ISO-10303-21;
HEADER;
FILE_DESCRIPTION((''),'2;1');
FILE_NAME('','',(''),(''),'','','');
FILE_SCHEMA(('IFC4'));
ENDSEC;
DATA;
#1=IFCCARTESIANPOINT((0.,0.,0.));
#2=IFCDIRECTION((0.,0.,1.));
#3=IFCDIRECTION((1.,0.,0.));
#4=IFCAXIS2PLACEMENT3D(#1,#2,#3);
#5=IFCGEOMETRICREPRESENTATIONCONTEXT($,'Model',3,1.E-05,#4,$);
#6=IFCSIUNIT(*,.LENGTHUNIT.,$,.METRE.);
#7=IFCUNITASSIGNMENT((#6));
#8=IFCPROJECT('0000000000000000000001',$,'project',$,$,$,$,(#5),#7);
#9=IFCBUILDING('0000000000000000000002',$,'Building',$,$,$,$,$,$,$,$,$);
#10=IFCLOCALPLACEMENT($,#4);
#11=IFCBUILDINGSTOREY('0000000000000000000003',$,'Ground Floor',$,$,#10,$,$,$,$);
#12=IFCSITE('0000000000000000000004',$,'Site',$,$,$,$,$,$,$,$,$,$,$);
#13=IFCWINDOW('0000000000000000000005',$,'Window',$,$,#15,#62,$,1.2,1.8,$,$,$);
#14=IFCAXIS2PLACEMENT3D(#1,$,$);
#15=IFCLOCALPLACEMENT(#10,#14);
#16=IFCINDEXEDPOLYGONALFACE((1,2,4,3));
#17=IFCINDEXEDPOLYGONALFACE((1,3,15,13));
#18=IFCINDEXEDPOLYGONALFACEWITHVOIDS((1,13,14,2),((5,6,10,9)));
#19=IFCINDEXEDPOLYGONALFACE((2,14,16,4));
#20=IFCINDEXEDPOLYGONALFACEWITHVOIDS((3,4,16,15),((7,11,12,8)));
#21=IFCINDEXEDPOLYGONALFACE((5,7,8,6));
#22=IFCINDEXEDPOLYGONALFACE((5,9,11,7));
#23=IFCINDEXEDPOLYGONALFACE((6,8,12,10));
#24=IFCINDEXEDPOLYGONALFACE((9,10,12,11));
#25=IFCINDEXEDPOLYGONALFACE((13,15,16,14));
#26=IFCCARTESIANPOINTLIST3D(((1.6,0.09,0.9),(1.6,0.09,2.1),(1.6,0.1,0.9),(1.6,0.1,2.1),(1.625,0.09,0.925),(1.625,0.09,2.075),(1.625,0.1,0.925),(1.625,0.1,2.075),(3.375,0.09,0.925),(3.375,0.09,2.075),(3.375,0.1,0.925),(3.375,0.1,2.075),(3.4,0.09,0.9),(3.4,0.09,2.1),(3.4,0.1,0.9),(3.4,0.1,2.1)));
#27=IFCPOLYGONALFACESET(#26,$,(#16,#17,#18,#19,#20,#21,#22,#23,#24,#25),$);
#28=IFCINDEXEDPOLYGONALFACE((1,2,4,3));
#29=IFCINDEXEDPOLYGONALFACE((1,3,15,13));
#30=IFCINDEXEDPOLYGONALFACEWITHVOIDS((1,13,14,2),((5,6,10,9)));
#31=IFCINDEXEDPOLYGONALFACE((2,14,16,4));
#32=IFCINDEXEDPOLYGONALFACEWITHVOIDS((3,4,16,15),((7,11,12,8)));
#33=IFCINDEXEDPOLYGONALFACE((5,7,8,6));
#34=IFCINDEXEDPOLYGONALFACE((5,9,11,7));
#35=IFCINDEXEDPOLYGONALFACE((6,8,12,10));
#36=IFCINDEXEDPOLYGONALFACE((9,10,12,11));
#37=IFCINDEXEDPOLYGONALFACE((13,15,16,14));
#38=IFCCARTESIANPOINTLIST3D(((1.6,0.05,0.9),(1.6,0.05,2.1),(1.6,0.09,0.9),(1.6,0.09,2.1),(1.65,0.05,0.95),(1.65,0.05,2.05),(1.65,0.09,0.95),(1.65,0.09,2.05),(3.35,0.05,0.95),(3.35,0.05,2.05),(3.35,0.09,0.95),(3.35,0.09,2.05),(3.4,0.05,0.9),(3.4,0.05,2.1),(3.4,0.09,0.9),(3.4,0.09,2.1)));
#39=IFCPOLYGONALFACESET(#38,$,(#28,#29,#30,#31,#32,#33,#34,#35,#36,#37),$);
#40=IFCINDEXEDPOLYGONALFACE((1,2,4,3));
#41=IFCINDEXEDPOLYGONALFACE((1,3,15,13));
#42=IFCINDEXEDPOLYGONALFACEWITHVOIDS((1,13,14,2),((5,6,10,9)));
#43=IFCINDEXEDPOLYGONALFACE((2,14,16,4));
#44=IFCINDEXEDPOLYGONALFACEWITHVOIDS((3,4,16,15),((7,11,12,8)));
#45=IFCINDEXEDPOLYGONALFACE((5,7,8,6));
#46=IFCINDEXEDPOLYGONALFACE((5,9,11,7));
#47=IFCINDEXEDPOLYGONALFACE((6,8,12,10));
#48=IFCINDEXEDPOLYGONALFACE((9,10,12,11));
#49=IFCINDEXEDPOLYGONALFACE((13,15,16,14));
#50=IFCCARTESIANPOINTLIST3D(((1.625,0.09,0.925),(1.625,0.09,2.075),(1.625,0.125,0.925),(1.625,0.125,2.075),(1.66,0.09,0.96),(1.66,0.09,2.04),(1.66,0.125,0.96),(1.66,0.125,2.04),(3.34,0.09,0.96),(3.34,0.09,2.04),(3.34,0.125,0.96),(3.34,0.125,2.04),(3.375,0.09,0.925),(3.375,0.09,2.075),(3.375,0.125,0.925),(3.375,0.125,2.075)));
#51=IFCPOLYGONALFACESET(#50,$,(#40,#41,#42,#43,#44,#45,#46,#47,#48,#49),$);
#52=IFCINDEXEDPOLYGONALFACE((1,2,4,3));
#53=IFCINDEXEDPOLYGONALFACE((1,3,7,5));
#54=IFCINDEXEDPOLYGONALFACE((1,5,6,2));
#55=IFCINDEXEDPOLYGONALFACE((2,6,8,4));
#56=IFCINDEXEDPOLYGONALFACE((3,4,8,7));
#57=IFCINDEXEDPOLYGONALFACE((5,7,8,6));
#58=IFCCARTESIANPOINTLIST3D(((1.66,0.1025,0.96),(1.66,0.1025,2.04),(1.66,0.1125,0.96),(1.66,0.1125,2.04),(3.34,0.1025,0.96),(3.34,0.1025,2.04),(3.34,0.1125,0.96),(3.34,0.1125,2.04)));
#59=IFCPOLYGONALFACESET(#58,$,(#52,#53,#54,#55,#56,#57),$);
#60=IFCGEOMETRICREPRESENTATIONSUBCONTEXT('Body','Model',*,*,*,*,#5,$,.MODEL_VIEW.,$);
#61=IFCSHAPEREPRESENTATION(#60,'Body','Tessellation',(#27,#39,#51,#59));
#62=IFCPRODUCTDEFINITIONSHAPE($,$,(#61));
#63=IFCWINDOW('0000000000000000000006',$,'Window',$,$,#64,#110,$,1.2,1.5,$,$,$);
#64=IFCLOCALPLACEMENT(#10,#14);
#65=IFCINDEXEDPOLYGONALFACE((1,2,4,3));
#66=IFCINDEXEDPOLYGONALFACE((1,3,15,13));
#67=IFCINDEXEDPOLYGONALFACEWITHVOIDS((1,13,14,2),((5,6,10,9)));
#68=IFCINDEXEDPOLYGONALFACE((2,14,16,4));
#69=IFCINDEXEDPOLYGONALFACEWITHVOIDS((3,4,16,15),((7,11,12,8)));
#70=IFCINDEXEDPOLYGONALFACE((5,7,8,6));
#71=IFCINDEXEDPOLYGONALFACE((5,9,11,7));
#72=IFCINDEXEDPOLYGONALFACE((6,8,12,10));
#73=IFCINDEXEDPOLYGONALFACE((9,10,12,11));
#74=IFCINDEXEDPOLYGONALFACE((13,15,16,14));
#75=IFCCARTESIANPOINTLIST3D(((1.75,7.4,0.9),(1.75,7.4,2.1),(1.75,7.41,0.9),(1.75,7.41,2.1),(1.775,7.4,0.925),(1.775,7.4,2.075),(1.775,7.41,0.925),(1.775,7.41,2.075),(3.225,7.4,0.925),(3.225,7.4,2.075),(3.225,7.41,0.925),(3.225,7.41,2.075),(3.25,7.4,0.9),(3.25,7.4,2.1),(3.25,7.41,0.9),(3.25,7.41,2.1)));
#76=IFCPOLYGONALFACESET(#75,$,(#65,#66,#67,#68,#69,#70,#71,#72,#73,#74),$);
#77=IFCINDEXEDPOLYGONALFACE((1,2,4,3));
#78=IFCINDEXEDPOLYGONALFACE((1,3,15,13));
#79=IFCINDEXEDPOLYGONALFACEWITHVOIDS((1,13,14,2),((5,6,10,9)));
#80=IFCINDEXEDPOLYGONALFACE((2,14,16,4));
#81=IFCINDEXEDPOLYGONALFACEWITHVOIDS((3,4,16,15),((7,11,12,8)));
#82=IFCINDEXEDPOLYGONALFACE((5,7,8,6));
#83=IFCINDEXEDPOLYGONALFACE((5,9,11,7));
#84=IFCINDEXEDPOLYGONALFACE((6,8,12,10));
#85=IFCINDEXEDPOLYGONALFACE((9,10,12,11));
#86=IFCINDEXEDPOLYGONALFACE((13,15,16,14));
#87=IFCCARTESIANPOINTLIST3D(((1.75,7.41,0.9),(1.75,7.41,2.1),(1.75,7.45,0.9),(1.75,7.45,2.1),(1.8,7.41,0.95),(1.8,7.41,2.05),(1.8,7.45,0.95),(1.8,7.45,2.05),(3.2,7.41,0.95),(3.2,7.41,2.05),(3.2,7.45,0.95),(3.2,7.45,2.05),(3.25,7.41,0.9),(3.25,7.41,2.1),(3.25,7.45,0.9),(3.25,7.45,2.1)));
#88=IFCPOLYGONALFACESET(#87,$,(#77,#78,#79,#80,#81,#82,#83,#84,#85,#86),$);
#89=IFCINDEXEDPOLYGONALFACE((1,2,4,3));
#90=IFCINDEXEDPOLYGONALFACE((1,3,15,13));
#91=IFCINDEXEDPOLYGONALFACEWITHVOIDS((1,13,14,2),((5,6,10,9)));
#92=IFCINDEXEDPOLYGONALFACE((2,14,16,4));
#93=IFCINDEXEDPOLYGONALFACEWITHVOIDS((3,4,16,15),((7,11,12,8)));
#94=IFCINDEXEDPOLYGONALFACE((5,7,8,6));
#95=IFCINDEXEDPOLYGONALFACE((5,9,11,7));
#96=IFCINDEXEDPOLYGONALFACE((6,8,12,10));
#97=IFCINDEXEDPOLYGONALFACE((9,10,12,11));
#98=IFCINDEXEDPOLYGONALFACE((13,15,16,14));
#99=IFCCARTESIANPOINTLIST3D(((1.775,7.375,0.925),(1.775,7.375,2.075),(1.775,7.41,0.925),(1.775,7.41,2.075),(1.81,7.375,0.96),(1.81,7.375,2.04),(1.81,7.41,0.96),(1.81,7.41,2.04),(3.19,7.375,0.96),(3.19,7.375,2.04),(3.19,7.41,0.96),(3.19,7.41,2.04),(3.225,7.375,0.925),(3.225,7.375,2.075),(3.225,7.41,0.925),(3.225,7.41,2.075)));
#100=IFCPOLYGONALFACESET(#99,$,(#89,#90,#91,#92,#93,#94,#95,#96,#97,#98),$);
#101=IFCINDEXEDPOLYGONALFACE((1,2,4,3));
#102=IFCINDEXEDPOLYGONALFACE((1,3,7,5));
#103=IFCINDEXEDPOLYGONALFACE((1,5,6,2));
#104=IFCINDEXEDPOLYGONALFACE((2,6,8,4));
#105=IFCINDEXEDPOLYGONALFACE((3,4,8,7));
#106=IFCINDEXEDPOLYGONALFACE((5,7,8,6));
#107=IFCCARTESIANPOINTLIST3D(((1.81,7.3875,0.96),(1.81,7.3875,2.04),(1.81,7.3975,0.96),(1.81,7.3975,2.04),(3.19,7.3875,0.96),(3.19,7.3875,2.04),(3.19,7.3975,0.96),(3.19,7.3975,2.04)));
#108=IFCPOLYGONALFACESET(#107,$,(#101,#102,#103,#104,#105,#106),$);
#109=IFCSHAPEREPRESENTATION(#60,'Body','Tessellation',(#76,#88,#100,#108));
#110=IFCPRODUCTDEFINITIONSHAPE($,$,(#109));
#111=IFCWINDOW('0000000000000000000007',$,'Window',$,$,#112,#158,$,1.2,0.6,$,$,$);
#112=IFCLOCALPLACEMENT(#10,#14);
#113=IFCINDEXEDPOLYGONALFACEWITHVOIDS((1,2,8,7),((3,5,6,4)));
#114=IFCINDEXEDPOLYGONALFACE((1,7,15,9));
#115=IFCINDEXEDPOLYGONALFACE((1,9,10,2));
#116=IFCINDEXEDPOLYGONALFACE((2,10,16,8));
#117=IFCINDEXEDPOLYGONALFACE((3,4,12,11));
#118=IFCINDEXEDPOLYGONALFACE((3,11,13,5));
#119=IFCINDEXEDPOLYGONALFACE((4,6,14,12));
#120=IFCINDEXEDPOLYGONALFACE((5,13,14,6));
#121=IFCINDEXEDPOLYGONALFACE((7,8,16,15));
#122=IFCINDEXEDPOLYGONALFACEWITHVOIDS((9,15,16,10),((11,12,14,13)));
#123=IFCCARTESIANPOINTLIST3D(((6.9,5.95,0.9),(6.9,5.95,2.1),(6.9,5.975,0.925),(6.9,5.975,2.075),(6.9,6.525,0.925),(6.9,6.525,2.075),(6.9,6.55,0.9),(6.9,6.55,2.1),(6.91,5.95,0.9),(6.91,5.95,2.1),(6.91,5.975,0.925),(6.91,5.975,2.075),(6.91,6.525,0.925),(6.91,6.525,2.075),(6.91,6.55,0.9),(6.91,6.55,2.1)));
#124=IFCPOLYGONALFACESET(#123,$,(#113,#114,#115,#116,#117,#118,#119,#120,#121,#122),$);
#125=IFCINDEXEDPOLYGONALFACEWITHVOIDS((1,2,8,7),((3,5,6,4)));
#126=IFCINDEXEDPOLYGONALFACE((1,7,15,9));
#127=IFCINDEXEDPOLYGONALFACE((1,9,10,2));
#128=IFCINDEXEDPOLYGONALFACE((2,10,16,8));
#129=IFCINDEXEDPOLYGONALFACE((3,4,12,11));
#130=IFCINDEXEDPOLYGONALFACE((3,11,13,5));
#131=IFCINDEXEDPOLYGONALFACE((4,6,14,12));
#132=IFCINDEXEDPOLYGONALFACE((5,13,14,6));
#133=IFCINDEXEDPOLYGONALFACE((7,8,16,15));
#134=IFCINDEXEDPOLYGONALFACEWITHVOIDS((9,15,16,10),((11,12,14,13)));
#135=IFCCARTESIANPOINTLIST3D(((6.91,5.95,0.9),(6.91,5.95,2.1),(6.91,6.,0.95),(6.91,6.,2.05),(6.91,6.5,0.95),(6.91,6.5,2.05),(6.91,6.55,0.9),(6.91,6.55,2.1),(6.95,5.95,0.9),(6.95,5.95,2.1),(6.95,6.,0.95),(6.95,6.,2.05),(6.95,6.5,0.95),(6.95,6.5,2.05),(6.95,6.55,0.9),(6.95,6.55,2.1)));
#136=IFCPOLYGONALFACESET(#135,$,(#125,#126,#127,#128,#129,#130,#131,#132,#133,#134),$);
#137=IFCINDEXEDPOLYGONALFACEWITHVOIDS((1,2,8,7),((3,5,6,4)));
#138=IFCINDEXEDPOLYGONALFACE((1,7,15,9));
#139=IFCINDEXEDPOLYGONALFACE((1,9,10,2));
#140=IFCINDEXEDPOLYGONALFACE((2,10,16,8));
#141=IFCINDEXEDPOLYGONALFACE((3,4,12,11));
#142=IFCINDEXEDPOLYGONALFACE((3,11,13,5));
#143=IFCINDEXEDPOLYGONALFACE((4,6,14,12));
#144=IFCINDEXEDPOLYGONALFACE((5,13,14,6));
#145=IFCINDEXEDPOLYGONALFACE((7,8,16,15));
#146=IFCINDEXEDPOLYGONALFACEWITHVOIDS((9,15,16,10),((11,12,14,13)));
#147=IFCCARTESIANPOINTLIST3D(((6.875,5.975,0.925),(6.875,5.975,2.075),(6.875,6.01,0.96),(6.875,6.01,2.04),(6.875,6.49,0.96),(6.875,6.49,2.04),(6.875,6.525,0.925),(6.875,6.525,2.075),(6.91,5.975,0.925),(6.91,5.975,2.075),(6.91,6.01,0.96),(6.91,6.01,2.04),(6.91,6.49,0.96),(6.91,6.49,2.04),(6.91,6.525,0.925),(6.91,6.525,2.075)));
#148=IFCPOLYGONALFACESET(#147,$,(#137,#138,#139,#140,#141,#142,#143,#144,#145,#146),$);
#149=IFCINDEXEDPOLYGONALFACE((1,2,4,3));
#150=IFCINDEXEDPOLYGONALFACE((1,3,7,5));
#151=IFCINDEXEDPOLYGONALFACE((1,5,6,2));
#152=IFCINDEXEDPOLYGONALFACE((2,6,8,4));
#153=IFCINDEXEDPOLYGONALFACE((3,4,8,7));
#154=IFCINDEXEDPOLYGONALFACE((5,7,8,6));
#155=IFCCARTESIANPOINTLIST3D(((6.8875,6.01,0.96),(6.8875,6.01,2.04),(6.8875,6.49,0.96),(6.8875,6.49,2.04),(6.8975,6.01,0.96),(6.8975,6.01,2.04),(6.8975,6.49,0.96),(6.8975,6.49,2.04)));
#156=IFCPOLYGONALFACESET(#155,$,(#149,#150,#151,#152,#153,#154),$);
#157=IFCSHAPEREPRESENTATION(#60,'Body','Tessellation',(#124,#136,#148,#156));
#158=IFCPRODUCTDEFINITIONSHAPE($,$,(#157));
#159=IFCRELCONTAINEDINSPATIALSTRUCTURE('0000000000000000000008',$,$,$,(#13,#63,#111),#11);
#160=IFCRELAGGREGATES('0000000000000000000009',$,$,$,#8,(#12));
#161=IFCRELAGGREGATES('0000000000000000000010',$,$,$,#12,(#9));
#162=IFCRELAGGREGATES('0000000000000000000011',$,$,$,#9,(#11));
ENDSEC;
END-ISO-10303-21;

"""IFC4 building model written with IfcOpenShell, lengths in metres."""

from ifc_helpers import new_model, si_unit, frame, origin_with_axes, place, context, subcontext, project, spatial, line, indexed_curve, outline, extrude, element, save


model = new_model("IFC4")

# Units and contexts
model_context = context("Model", 3, precision=1e-05, world=origin_with_axes())
body_context = subcontext(model_context, "Body", "Model", "MODEL_VIEW")
ifc_project = project(units=[si_unit("LENGTHUNIT", "METRE")], contexts=[model_context])

# Site, building, storey
site = spatial("IfcSite", under=ifc_project, Name="Site")
building = spatial("IfcBuilding", under=site, Name="Building")
storey_placement = place(None, origin_with_axes())
storey = spatial("IfcBuildingStorey", under=building, at=storey_placement, Name="Ground Floor")

# Windows
window_1_placement = place(storey_placement, frame((1.6, 0.0, 0.9), z_axis=(0.0, 0.0, 1.0), x_axis=(1.0, 0.0, 0.0)))
element("IfcWindow", 1, at=window_1_placement, inside=storey, Name="Window", OverallHeight=1.2, OverallWidth=1.8, context=body_context, shape_type="SweptSolid", body=[
    extrude(outline(indexed_curve([(0.0, 0.0), (1.8, 0.0), (1.8, 1.2), (0.0, 1.2)], segments=[line(1, 2, 3, 4, 1)]), holes=[indexed_curve([(0.025, 0.025), (1.775, 0.025), (1.775, 1.175), (0.025, 1.175)], segments=[line(1, 2, 3, 4, 1)])]), frame((0.0, 0.09, 0.0), z_axis=(0.0, -1.0, 0.0), x_axis=(1.0, 0.0, 0.0)), (0.0, 0.0, -1.0), 0.01),
    extrude(outline(indexed_curve([(0.0, 0.0), (1.8, 0.0), (1.8, 1.2), (0.0, 1.2)], segments=[line(1, 2, 3, 4, 1)]), holes=[indexed_curve([(0.05, 0.05), (1.75, 0.05), (1.75, 1.15), (0.05, 1.15)], segments=[line(1, 2, 3, 4, 1)])]), frame((0.0, 0.05, 0.0), z_axis=(0.0, -1.0, 0.0), x_axis=(1.0, 0.0, 0.0)), (0.0, 0.0, -1.0), 0.04),
    extrude(outline(indexed_curve([(0.0, 0.0), (1.75, 0.0), (1.75, 1.15), (0.0, 1.15)], segments=[line(1, 2, 3, 4, 1)]), holes=[indexed_curve([(0.035, 0.035), (1.715, 0.035), (1.715, 1.115), (0.035, 1.115)], segments=[line(1, 2, 3, 4, 1)])]), frame((0.025, 0.09, 0.025), z_axis=(0.0, -1.0, 0.0), x_axis=(1.0, 0.0, 0.0)), (0.0, 0.0, -1.0), 0.035),
    extrude(outline(indexed_curve([(0.035, 0.035), (1.715, 0.035), (1.715, 1.115), (0.035, 1.115)], segments=[line(1, 2, 3, 4, 1)])), frame((0.025, 0.1025, 0.025), z_axis=(0.0, -1.0, 0.0), x_axis=(1.0, 0.0, 0.0)), (0.0, 0.0, -1.0), 0.01),
])
window_2_placement = place(storey_placement, frame((3.25, 7.5, 0.9), z_axis=(0.0, 0.0, 1.0), x_axis=(-1.0, 0.0, 0.0)))
element("IfcWindow", 2, at=window_2_placement, inside=storey, Name="Window", OverallHeight=1.2, OverallWidth=1.5, context=body_context, shape_type="SweptSolid", body=[
    extrude(outline(indexed_curve([(0.0, 0.0), (1.5, 0.0), (1.5, 1.2), (0.0, 1.2)], segments=[line(1, 2, 3, 4, 1)]), holes=[indexed_curve([(0.025, 0.025), (1.475, 0.025), (1.475, 1.175), (0.025, 1.175)], segments=[line(1, 2, 3, 4, 1)])]), frame((0.0, 0.09, 0.0), z_axis=(0.0, -1.0, 0.0), x_axis=(1.0, 0.0, 0.0)), (0.0, 0.0, -1.0), 0.01),
    extrude(outline(indexed_curve([(0.0, 0.0), (1.5, 0.0), (1.5, 1.2), (0.0, 1.2)], segments=[line(1, 2, 3, 4, 1)]), holes=[indexed_curve([(0.05, 0.05), (1.45, 0.05), (1.45, 1.15), (0.05, 1.15)], segments=[line(1, 2, 3, 4, 1)])]), frame((0.0, 0.05, 0.0), z_axis=(0.0, -1.0, 0.0), x_axis=(1.0, 0.0, 0.0)), (0.0, 0.0, -1.0), 0.04),
    extrude(outline(indexed_curve([(0.0, 0.0), (1.45, 0.0), (1.45, 1.15), (0.0, 1.15)], segments=[line(1, 2, 3, 4, 1)]), holes=[indexed_curve([(0.035, 0.035), (1.415, 0.035), (1.415, 1.115), (0.035, 1.115)], segments=[line(1, 2, 3, 4, 1)])]), frame((0.025, 0.09, 0.025), z_axis=(0.0, -1.0, 0.0), x_axis=(1.0, 0.0, 0.0)), (0.0, 0.0, -1.0), 0.035),
    extrude(outline(indexed_curve([(0.035, 0.035), (1.415, 0.035), (1.415, 1.115), (0.035, 1.115)], segments=[line(1, 2, 3, 4, 1)])), frame((0.025, 0.1025, 0.025), z_axis=(0.0, -1.0, 0.0), x_axis=(1.0, 0.0, 0.0)), (0.0, 0.0, -1.0), 0.01),
])
window_3_placement = place(storey_placement, frame((7.0, 5.95, 0.9), z_axis=(0.0, 0.0, 1.0), x_axis=(0.0, 1.0, 0.0)))
element("IfcWindow", 3, at=window_3_placement, inside=storey, Name="Window", OverallHeight=1.2, OverallWidth=0.6, context=body_context, shape_type="SweptSolid", body=[
    extrude(outline(indexed_curve([(0.0, 0.0), (0.6, 0.0), (0.6, 1.2), (0.0, 1.2)], segments=[line(1, 2, 3, 4, 1)]), holes=[indexed_curve([(0.025, 0.025), (0.575, 0.025), (0.575, 1.175), (0.025, 1.175)], segments=[line(1, 2, 3, 4, 1)])]), frame((0.0, 0.09, 0.0), z_axis=(0.0, -1.0, 0.0), x_axis=(1.0, 0.0, 0.0)), (0.0, 0.0, -1.0), 0.01),
    extrude(outline(indexed_curve([(0.0, 0.0), (0.6, 0.0), (0.6, 1.2), (0.0, 1.2)], segments=[line(1, 2, 3, 4, 1)]), holes=[indexed_curve([(0.05, 0.05), (0.55, 0.05), (0.55, 1.15), (0.05, 1.15)], segments=[line(1, 2, 3, 4, 1)])]), frame((0.0, 0.05, 0.0), z_axis=(0.0, -1.0, 0.0), x_axis=(1.0, 0.0, 0.0)), (0.0, 0.0, -1.0), 0.04),
    extrude(outline(indexed_curve([(0.0, 0.0), (0.55, 0.0), (0.55, 1.15), (0.0, 1.15)], segments=[line(1, 2, 3, 4, 1)]), holes=[indexed_curve([(0.035, 0.035), (0.515, 0.035), (0.515, 1.115), (0.035, 1.115)], segments=[line(1, 2, 3, 4, 1)])]), frame((0.025, 0.09, 0.025), z_axis=(0.0, -1.0, 0.0), x_axis=(1.0, 0.0, 0.0)), (0.0, 0.0, -1.0), 0.035),
    extrude(outline(indexed_curve([(0.035, 0.035), (0.515, 0.035), (0.515, 1.115), (0.035, 1.115)], segments=[line(1, 2, 3, 4, 1)])), frame((0.025, 0.1025, 0.025), z_axis=(0.0, -1.0, 0.0), x_axis=(1.0, 0.0, 0.0)), (0.0, 0.0, -1.0), 0.01),
])

save(model, "model.ifc")
